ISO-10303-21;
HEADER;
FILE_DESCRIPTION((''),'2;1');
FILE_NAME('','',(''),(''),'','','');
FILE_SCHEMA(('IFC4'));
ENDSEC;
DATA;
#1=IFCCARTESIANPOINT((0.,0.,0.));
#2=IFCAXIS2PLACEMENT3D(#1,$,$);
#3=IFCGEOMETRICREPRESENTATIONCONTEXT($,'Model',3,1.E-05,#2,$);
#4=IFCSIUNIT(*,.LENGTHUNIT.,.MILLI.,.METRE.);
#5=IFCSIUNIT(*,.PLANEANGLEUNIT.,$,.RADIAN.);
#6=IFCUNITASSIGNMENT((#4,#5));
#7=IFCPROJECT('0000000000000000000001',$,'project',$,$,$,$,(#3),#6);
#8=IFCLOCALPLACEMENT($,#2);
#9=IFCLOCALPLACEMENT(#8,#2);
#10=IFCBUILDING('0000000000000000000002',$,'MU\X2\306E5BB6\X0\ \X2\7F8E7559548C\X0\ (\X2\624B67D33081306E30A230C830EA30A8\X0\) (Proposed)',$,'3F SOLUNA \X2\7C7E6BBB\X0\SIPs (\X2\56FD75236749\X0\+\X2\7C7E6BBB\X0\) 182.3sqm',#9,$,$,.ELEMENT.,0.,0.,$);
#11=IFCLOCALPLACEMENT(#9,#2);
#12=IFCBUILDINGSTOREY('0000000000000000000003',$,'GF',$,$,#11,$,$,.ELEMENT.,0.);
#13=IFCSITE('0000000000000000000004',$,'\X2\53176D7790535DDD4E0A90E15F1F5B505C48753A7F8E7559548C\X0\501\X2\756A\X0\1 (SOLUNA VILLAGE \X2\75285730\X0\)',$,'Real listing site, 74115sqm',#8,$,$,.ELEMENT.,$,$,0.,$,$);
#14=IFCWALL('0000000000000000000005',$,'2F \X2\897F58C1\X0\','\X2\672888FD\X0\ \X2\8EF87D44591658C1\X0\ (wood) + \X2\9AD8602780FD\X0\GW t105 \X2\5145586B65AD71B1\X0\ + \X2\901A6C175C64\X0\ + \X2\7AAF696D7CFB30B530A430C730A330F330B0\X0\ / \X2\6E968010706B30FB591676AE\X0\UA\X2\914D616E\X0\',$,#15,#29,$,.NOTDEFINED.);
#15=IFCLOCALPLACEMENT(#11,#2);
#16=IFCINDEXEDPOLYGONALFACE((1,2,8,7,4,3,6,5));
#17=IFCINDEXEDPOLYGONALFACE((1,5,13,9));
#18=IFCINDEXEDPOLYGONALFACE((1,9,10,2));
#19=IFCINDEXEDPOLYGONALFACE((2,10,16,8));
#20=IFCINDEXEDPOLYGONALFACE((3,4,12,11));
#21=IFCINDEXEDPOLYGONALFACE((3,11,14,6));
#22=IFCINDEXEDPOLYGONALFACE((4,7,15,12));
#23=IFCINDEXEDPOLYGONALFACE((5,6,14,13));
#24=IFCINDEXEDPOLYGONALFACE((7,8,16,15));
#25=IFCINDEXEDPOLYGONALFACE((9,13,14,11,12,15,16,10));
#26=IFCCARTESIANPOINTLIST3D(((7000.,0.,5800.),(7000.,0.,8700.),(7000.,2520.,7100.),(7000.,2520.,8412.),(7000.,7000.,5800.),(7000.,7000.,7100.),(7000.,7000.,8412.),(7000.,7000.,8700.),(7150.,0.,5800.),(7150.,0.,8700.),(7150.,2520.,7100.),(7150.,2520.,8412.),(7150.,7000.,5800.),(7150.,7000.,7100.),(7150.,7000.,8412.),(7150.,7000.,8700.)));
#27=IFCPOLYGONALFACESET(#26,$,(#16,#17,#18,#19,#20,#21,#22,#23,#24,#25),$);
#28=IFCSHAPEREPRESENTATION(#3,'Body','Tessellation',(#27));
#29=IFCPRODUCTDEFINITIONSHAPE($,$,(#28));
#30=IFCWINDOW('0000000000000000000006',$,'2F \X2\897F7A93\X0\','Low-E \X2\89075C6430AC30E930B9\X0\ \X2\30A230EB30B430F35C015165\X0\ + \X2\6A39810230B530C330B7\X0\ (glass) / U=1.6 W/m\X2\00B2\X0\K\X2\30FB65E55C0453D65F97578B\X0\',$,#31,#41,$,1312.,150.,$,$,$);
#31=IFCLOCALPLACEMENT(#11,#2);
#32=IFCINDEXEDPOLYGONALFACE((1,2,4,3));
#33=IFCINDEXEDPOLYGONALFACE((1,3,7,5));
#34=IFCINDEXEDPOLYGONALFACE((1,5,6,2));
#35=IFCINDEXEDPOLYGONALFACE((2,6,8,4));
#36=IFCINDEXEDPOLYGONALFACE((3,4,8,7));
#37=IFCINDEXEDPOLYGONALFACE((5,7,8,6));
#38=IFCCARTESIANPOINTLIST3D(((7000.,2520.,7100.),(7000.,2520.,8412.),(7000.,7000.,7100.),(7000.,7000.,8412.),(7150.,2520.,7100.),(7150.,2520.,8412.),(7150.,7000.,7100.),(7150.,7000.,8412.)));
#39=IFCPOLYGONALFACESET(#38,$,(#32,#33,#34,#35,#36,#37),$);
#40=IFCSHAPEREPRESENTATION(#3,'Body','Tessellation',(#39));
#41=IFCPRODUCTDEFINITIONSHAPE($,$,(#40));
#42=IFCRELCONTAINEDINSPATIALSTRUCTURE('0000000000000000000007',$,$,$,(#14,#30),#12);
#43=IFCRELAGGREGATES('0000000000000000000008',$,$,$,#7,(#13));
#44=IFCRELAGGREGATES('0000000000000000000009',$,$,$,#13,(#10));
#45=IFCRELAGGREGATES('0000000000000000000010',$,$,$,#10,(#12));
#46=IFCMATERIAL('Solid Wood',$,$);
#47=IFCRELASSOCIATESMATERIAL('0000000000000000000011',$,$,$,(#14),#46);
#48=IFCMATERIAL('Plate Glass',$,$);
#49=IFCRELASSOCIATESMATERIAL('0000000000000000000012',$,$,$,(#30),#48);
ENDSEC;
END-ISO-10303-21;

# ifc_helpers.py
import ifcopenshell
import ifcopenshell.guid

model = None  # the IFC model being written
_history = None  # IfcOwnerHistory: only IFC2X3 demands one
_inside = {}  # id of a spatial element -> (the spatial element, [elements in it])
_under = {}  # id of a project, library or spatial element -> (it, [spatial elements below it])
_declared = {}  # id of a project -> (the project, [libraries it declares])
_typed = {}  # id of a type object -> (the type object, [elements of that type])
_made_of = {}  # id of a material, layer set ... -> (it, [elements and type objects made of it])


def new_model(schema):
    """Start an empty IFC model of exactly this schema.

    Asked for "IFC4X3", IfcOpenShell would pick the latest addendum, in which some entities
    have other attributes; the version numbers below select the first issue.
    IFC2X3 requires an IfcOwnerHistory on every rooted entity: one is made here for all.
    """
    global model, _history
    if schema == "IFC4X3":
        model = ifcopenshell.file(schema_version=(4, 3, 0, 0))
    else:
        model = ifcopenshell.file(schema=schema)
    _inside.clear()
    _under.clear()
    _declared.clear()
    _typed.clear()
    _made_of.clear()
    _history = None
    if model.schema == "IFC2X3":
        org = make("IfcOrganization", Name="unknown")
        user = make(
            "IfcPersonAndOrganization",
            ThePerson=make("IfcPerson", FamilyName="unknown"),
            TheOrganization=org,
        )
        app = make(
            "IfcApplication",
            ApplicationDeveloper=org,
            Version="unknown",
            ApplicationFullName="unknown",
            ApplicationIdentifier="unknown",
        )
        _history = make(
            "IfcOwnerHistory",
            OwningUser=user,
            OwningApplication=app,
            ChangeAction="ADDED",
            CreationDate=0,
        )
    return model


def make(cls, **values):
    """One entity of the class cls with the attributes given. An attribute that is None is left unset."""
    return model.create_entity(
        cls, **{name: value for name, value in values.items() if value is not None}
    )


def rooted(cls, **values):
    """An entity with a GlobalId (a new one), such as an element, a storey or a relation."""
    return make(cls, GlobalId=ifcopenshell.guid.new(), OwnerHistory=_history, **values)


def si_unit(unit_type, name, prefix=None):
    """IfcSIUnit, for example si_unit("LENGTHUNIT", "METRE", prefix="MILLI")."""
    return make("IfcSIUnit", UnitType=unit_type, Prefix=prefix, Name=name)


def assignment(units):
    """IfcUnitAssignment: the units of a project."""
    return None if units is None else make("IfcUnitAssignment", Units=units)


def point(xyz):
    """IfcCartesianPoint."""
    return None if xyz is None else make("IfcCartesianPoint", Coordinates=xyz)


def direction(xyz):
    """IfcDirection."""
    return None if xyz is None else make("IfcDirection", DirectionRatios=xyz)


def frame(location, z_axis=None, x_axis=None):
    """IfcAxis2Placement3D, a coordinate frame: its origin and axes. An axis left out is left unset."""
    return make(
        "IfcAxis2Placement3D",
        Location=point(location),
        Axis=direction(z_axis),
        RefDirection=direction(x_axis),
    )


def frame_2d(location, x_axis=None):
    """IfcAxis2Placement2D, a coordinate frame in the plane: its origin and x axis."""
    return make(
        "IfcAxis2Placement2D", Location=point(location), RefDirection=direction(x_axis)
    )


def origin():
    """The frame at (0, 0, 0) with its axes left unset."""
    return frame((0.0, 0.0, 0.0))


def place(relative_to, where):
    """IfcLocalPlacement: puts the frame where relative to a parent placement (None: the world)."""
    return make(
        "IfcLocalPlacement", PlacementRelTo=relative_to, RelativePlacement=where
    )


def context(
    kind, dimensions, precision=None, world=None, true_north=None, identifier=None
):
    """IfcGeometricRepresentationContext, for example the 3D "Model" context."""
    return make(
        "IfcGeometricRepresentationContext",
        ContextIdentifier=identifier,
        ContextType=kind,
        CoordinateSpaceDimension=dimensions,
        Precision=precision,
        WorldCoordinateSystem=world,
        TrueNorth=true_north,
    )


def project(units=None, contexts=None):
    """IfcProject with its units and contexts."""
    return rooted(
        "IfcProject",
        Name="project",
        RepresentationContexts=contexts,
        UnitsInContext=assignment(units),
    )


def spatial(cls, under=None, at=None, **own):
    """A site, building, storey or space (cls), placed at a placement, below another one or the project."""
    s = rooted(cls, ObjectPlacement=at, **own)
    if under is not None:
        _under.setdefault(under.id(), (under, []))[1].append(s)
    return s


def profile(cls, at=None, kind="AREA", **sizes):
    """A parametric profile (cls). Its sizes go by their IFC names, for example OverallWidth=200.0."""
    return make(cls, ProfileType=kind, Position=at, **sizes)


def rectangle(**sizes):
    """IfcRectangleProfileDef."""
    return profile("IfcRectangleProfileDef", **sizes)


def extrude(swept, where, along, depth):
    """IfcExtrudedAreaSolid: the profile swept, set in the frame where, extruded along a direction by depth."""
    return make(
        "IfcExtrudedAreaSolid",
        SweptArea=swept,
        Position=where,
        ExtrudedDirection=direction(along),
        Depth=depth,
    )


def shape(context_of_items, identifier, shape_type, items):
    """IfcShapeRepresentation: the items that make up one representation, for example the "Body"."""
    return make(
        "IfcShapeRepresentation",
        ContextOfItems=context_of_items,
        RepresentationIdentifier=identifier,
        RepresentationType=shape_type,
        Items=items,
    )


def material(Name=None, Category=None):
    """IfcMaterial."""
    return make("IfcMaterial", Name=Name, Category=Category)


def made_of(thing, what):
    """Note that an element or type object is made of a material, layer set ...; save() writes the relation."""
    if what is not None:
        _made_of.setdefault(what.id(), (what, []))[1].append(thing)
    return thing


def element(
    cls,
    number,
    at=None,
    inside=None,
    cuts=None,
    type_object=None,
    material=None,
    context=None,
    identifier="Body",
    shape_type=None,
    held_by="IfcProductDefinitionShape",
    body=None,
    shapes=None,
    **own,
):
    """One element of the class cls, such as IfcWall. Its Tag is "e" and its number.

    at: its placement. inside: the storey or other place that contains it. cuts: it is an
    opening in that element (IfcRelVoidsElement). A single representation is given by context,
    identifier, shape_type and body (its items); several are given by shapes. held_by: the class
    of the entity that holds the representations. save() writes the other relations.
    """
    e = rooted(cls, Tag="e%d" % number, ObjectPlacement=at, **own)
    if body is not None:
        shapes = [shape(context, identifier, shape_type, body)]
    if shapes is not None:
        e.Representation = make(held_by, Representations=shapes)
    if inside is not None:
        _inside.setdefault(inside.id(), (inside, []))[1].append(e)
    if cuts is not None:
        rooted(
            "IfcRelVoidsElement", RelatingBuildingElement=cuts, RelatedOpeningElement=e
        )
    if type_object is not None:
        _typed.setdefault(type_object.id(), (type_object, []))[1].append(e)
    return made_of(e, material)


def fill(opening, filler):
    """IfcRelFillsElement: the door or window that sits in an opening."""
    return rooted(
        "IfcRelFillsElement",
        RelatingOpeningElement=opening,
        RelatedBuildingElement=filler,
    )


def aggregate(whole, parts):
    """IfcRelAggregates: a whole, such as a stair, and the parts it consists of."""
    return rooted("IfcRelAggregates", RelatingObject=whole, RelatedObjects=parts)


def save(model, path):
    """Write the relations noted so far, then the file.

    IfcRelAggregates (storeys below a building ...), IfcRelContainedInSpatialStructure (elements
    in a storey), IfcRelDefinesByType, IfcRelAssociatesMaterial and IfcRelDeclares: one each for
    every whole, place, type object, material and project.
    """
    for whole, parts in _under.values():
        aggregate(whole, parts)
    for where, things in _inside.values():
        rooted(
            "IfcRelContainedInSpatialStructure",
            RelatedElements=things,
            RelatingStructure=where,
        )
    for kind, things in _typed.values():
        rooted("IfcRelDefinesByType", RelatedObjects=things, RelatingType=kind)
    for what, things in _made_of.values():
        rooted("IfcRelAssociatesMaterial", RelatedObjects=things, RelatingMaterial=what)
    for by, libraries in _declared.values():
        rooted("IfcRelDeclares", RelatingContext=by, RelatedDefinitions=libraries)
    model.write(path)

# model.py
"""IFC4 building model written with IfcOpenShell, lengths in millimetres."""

from ifc_helpers import new_model, si_unit, frame, frame_2d, origin, place, context, project, spatial, rectangle, extrude, material, element, fill, save


model = new_model("IFC4")

# Units and contexts
model_context = context("Model", 3, precision=1e-05, world=origin())
ifc_project = project(units=[si_unit("LENGTHUNIT", "METRE", prefix="MILLI"), si_unit("PLANEANGLEUNIT", "RADIAN")], contexts=[model_context])

# Site, building, storey
site_placement = place(None, origin())
site = spatial("IfcSite", under=ifc_project, at=site_placement, Name="北海道川上郡弟子屈町美留和501番1 (SOLUNA VILLAGE 用地)", ObjectType="Real listing site, 74115sqm", CompositionType="ELEMENT", RefElevation=0.0)
building_placement = place(site_placement, origin())
building = spatial("IfcBuilding", under=site, at=building_placement, Name="MUの家 美留和 (手染めのアトリエ) (Proposed)", ObjectType="3F SOLUNA 籾殻SIPs (国産杉+籾殻) 182.3sqm", CompositionType="ELEMENT", ElevationOfRefHeight=0.0, ElevationOfTerrain=0.0)
storey_placement = place(building_placement, origin())
storey = spatial("IfcBuildingStorey", under=building, at=storey_placement, Name="GF", CompositionType="ELEMENT", Elevation=0.0)

# Shared definitions
ifc_material_1 = material(Name="Solid Wood")

# Shared definitions
ifc_material_2 = material(Name="Plate Glass")

# Wall, opening, window
wall_1_placement = place(storey_placement, frame((3500.0, 0.0, 2900.0)))
wall_1 = element("IfcWall", 1, at=wall_1_placement, inside=storey, material=ifc_material_1, Name="2F 西壁", Description="木製 軸組外壁 (wood) + 高性能GW t105 充填断熱 + 通気層 + 窯業系サイディング / 準耐火・外皮UA配慮", PredefinedType="NOTDEFINED", context=model_context, shape_type="SweptSolid", body=[
    extrude(rectangle(XDim=150.0, YDim=7000.0, at=frame_2d((75.0, 3500.0))), frame((3500.0, 0.0, 2900.0)), (0.0, 0.0, 1.0), 2900.0),
])
opening_1_placement = place(storey_placement, frame((3500.0, 1260.0, 3550.0)))
opening_1 = element("IfcOpeningElement", 2, at=opening_1_placement, cuts=wall_1, PredefinedType="NOTDEFINED", context=model_context, shape_type="SweptSolid", body=[
    extrude(rectangle(XDim=150.0, YDim=4480.0, at=frame_2d((75.0, 2240.0))), frame((3500.0, 1260.0, 3550.0)), (0.0, 0.0, 1.0), 1312.0),
])
window_1_placement = place(storey_placement, frame((3500.0, 1260.0, 3550.0)))
window_1 = element("IfcWindow", 3, at=window_1_placement, inside=storey, material=ifc_material_2, Name="2F 西窓", Description="Low-E 複層ガラス アルゴン封入 + 樹脂サッシ (glass) / U=1.6 W/m²K・日射取得型", OverallHeight=1312.0, OverallWidth=150.0, context=model_context, shape_type="SweptSolid", body=[
    extrude(rectangle(XDim=150.0, YDim=4480.0, at=frame_2d((75.0, 2240.0))), frame((3500.0, 1260.0, 3550.0)), (0.0, 0.0, 1.0), 1312.0),
])
fill(opening_1, window_1)

save(model, "model.ifc")
